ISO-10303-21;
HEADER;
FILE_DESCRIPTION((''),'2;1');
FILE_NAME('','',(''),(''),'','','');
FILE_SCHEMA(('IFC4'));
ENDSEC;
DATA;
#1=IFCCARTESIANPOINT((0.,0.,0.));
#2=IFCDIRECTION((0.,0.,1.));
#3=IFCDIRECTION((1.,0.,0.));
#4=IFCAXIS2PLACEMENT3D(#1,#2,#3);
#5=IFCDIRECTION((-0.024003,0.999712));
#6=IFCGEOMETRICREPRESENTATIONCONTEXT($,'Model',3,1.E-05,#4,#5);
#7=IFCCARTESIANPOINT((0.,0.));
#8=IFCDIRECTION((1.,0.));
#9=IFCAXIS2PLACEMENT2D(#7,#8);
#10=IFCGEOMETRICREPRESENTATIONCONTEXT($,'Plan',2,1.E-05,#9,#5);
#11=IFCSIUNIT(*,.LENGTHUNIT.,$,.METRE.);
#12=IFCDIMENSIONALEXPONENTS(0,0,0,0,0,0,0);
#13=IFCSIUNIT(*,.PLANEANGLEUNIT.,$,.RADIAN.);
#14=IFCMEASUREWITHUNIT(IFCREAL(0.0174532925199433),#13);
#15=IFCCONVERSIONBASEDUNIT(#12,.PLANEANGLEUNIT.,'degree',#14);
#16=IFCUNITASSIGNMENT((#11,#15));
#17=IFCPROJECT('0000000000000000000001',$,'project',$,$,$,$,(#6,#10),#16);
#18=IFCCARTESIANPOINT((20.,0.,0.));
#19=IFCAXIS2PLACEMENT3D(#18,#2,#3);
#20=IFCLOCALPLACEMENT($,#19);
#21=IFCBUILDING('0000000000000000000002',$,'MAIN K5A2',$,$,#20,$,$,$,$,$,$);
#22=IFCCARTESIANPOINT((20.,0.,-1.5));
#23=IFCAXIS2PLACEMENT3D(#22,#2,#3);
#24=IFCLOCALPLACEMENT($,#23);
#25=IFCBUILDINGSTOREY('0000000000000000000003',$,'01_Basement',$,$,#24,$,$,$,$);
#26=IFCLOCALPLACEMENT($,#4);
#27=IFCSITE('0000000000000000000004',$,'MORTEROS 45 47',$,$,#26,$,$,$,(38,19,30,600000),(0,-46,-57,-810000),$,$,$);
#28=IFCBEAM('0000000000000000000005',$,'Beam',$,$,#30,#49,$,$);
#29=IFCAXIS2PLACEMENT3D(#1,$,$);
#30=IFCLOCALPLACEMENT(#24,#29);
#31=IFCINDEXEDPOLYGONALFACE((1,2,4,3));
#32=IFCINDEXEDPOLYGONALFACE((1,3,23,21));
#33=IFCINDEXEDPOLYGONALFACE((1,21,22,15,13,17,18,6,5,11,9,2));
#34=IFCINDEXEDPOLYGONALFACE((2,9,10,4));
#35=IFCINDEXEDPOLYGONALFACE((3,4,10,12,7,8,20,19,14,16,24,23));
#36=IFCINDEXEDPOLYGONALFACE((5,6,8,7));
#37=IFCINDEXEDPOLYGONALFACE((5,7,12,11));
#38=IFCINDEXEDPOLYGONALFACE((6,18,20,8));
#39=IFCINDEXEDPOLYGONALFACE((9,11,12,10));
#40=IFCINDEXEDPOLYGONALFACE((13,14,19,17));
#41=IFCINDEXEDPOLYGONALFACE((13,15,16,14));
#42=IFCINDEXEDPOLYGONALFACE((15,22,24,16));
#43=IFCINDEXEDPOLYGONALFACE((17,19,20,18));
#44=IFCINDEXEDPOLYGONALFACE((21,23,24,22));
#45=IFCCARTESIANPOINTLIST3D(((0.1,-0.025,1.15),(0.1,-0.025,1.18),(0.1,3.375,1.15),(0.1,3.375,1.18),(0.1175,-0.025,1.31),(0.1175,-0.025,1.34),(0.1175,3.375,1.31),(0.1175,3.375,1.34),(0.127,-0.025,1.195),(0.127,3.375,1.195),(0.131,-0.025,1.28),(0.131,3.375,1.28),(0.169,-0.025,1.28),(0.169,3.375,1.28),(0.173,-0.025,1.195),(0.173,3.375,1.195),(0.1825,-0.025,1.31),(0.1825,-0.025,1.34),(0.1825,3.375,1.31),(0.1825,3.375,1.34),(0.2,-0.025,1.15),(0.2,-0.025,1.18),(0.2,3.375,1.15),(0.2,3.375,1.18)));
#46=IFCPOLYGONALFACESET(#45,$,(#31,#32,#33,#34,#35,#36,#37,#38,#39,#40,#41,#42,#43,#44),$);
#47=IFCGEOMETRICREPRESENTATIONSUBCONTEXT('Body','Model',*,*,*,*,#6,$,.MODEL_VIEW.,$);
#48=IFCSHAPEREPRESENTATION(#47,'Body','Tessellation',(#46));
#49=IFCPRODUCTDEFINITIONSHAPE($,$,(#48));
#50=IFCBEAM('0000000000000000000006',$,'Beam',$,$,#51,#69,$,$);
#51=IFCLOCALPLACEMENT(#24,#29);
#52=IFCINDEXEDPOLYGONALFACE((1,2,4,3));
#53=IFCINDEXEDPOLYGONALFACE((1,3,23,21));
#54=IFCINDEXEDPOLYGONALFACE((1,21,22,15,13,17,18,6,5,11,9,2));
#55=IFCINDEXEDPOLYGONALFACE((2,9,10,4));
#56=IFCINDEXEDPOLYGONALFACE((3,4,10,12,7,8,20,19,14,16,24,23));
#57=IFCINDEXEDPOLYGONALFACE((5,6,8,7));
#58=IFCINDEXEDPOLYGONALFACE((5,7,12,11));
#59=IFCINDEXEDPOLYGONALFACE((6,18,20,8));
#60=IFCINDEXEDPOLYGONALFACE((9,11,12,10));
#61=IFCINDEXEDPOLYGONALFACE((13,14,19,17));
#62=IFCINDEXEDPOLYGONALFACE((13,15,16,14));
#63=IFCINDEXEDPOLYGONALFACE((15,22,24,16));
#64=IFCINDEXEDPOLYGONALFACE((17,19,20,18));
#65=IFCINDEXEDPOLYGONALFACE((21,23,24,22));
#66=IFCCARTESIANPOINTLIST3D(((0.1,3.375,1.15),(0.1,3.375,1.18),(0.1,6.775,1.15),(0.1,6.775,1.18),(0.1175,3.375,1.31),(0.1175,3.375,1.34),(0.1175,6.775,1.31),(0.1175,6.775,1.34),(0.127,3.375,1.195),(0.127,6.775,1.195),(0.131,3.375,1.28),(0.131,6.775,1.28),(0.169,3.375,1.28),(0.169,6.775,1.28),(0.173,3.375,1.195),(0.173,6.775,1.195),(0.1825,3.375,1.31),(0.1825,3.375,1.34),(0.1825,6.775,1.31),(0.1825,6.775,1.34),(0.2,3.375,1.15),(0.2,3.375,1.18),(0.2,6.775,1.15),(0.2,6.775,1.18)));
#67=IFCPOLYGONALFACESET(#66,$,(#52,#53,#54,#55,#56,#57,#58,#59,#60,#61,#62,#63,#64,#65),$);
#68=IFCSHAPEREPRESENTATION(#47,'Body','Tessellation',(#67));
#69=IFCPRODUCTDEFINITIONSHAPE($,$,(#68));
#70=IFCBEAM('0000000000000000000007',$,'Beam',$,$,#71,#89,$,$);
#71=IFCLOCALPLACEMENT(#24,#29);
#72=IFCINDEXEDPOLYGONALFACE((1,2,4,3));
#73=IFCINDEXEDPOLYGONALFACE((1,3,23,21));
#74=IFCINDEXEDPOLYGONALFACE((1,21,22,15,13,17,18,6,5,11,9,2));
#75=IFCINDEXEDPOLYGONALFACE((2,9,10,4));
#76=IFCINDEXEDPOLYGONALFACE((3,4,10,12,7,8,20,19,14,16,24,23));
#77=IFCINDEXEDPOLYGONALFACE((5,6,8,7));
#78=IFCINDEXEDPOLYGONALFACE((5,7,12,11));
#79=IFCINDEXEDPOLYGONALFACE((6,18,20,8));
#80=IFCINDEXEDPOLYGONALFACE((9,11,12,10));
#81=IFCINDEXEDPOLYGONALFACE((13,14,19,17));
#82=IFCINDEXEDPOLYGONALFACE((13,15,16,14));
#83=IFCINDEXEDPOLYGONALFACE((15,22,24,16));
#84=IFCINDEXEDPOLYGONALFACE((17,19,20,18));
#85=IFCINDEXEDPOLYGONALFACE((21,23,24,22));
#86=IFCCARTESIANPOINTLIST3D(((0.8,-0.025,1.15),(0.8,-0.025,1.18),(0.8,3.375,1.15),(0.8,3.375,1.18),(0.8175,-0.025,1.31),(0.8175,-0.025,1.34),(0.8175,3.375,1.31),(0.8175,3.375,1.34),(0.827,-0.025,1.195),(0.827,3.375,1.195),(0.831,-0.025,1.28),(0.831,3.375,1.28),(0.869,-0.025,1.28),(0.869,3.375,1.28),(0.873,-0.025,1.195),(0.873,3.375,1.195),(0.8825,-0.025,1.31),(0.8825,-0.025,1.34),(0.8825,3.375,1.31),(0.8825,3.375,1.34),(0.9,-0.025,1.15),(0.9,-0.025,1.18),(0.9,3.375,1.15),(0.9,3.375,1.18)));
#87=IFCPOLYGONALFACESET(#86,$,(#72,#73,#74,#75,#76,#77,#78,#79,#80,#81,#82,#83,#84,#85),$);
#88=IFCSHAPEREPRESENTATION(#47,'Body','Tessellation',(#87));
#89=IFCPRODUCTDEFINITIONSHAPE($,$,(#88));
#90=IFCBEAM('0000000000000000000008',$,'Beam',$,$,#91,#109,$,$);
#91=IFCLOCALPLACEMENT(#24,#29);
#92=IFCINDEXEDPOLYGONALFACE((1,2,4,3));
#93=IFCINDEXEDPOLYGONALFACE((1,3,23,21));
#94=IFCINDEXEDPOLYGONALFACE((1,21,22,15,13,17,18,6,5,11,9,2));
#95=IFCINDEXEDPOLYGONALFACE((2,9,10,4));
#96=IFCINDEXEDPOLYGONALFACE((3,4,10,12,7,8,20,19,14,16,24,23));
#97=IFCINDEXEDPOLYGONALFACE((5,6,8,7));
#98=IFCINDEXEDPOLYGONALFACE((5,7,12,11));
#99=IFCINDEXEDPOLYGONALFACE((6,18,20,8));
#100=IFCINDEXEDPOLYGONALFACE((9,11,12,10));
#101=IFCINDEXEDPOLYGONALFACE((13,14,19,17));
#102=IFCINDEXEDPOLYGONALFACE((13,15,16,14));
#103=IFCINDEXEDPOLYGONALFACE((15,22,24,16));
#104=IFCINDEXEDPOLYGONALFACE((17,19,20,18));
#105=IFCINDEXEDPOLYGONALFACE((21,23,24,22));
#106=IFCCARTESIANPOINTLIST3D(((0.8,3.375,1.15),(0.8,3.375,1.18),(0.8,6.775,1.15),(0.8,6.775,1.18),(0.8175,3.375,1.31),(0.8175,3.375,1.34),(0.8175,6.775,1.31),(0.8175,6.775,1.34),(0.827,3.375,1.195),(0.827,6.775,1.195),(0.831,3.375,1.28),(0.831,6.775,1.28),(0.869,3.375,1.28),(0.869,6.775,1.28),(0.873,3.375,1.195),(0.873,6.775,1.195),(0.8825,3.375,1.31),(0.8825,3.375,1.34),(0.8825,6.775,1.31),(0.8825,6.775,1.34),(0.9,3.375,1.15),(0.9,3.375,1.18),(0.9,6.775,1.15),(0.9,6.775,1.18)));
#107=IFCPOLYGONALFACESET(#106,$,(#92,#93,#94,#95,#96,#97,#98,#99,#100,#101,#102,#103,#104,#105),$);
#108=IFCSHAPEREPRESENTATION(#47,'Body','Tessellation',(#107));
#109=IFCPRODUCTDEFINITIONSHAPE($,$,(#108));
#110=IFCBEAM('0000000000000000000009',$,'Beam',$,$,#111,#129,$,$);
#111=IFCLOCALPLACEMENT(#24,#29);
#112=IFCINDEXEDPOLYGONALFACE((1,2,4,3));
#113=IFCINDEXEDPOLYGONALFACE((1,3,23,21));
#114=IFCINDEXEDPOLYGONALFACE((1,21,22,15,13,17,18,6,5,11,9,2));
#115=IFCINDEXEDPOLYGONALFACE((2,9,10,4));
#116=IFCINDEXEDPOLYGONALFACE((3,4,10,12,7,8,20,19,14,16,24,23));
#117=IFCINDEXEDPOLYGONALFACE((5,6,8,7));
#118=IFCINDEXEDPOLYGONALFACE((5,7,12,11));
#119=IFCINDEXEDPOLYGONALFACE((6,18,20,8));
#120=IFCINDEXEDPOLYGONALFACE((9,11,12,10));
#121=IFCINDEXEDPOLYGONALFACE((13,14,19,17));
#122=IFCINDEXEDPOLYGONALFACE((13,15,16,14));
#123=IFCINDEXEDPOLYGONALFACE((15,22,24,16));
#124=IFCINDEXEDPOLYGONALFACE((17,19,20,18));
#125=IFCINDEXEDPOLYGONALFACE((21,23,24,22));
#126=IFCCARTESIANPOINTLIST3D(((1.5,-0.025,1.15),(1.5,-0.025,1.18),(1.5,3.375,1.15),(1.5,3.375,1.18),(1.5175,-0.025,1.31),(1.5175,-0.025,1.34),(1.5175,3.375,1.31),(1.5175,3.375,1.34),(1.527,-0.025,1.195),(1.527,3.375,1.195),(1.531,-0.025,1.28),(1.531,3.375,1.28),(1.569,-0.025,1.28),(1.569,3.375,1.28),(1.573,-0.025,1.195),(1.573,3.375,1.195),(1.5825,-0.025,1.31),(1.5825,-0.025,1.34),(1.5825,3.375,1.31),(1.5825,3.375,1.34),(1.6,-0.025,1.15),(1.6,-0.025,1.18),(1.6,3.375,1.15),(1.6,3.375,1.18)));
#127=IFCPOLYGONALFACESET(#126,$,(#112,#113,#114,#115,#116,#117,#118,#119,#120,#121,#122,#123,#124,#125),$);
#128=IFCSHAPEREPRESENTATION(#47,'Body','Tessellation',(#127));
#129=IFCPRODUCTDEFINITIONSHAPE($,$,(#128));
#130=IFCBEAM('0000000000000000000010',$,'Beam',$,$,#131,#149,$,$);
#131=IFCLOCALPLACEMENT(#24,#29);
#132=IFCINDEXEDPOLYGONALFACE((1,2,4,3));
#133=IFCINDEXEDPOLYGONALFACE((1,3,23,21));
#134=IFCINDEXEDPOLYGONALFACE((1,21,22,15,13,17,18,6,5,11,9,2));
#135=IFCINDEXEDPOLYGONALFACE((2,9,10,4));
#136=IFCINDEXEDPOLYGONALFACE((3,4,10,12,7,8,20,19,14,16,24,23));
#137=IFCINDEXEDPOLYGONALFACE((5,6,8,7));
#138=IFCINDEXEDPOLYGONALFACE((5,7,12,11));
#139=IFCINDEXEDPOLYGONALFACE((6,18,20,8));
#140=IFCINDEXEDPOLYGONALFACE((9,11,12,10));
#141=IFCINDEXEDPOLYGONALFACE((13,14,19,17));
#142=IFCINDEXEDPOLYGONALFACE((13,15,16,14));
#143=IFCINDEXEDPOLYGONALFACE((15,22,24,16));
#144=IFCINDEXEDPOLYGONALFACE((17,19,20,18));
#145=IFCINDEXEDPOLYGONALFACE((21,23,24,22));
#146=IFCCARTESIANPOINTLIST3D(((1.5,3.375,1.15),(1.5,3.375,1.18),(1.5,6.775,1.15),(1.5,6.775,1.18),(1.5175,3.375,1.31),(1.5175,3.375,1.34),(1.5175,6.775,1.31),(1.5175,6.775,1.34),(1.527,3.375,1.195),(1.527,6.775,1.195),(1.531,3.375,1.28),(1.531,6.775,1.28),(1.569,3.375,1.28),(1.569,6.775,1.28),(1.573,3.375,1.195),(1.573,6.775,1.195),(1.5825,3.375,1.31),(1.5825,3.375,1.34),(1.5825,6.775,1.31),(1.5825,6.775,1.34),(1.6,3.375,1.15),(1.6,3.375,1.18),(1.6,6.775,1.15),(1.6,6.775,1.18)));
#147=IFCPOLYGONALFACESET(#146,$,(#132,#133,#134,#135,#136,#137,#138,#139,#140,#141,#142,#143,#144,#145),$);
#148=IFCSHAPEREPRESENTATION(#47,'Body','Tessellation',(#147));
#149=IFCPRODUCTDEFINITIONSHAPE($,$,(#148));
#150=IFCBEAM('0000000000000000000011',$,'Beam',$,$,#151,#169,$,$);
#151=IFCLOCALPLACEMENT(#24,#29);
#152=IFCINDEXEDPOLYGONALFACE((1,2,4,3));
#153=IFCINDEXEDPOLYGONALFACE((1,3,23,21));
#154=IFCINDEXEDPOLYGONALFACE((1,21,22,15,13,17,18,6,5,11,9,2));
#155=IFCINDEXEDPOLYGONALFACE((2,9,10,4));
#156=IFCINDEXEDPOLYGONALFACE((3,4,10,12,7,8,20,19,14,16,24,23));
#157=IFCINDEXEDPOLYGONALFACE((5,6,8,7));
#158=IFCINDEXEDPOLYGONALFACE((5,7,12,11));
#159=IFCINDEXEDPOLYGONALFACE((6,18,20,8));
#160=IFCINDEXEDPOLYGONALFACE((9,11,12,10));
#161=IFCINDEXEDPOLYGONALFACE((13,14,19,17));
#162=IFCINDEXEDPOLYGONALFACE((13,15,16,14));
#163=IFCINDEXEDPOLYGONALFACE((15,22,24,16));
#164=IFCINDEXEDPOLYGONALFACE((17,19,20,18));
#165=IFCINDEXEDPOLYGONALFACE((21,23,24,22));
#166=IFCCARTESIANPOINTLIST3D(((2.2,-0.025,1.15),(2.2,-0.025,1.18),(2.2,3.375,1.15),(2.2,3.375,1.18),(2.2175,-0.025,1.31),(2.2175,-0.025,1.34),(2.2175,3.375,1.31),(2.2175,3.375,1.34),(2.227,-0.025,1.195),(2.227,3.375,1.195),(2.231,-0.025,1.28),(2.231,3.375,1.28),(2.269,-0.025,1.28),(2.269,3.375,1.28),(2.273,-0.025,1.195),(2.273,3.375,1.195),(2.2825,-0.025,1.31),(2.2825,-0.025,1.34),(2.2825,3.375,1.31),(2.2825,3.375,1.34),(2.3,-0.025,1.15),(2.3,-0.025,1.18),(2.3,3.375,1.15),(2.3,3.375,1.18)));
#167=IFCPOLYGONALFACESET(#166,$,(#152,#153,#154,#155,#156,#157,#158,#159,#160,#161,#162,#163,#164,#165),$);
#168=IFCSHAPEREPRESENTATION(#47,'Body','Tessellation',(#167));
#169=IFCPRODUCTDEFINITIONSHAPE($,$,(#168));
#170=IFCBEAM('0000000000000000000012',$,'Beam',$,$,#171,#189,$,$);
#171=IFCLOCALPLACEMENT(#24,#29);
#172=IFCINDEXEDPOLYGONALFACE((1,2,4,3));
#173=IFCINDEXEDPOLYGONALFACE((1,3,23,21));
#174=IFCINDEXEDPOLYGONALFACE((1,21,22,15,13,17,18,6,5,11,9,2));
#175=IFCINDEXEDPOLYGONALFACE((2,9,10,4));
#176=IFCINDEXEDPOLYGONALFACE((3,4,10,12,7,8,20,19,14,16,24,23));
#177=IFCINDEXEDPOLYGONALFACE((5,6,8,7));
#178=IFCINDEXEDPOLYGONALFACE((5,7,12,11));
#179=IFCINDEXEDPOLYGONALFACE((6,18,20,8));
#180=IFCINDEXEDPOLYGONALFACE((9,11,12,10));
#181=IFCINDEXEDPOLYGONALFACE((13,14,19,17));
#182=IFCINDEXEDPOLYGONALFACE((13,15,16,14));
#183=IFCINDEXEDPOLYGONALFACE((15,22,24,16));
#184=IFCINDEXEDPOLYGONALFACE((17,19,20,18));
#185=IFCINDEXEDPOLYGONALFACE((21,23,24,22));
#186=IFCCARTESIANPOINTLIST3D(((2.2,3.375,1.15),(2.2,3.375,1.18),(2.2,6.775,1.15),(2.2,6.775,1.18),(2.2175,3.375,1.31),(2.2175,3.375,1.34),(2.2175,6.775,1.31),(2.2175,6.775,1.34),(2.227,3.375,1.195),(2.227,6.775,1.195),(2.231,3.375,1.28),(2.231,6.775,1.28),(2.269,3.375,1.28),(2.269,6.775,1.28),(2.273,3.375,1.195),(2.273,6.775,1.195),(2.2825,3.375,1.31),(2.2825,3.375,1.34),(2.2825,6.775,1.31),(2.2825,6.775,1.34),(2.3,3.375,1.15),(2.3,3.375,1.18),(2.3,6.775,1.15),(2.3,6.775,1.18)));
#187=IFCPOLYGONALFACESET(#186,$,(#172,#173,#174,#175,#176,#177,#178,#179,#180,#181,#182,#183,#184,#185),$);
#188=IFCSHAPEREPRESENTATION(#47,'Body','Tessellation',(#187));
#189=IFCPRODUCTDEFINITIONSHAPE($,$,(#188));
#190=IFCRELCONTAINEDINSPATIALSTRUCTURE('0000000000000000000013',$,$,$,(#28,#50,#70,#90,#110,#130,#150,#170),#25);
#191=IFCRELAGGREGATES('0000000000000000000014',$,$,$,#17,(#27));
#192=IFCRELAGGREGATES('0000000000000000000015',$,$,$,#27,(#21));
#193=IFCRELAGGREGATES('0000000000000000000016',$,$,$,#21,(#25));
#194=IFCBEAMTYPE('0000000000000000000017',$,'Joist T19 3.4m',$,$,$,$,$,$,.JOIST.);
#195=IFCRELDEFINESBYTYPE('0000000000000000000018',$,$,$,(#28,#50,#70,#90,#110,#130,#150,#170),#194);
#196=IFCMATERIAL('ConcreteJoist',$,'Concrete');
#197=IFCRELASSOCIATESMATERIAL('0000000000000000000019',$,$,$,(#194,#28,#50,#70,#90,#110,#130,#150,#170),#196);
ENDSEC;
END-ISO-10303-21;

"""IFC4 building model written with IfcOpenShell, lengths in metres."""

from ifc_helpers import new_model, entity, si_unit, converted_unit, direction, frame, origin_with_axes, origin_2d_with_axis, place, context, subcontext, project, spatial, indexed_curve, outline, extrude, material, material_profile, profile_set, profile_usage, type_object, element, save


model = new_model("IFC4")

# Units and contexts
model_context = context("Model", 3, precision=1e-05, world=origin_with_axes(), true_north=direction((-0.024003, 0.999712)))
plan_context = context("Plan", 2, precision=1e-05, world=origin_2d_with_axis(), true_north=direction((-0.024003, 0.999712)))
body_context = subcontext(model_context, "Body", "Model", "MODEL_VIEW")
ifc_project = project(units=[si_unit("LENGTHUNIT", "METRE"), converted_unit("PLANEANGLEUNIT", "degree", entity("IfcReal", 0.0174532925199433), si_unit("PLANEANGLEUNIT", "RADIAN"), dimensions=[0, 0, 0, 0, 0, 0, 0])], contexts=[model_context, plan_context])

# Site, building, storey
site_placement = place(None, origin_with_axes())
site = spatial("IfcSite", under=ifc_project, at=site_placement, Name="MORTEROS 45 47", RefLatitude=(38, 19, 30, 600000), RefLongitude=(0, -46, -57, -810000))
building_placement = place(None, frame((20.0, 0.0, 0.0), z_axis=(0.0, 0.0, 1.0), x_axis=(1.0, 0.0, 0.0)))
building = spatial("IfcBuilding", under=site, at=building_placement, Name="MAIN K5A2")
storey_placement = place(None, frame((20.0, 0.0, -1.5), z_axis=(0.0, 0.0, 1.0), x_axis=(1.0, 0.0, 0.0)))
storey = spatial("IfcBuildingStorey", under=building, at=storey_placement, Name="01_Basement")

# Beams
ifc_material = material(Name="ConcreteJoist", Category="Concrete")
ifc_material_profile = material_profile(ifc_material, outline(indexed_curve([(0.019, 0.13), (0.023, 0.045), (0.05, 0.03), (0.05, 0.0), (-0.05, 0.0), (-0.05, 0.03), (-0.023, 0.045), (-0.019, 0.13), (-0.0325, 0.16), (-0.0325, 0.19), (0.0325, 0.19), (0.0325, 0.16), (0.019, 0.13)])))
ifc_profile_set = profile_set([ifc_material_profile], Name="JoistMaterialProfileSet")
ifc_profile_usage_1 = profile_usage(ifc_profile_set, cardinal=5)
beam_type = type_object("IfcBeamType", Name="Joist T19 3.4m", PredefinedType="JOIST", material=ifc_profile_set)
beam_1_placement = place(None, frame((20.15, -0.025, -0.35), z_axis=(0.0, 1.0, 0.0), x_axis=(-1.0, 0.0, 0.0)))
element("IfcBeam", 1, at=beam_1_placement, inside=storey, type_object=beam_type, material=ifc_profile_usage_1, Name="Beam", context=body_context, shape_type="SweptSolid", body=[
    extrude(outline(indexed_curve([(0.019, 0.13), (0.023, 0.045), (0.05, 0.03), (0.05, 0.0), (-0.05, 0.0), (-0.05, 0.03), (-0.023, 0.045), (-0.019, 0.13), (-0.0325, 0.16), (-0.0325, 0.19), (0.0325, 0.19), (0.0325, 0.16), (0.019, 0.13)])), origin_with_axes(), (0.0, 0.0, 1.0), 3.4),
])
ifc_profile_usage_2 = profile_usage(ifc_profile_set, cardinal=5)
beam_2_placement = place(None, frame((20.15, 3.375, -0.35), z_axis=(0.0, 1.0, 0.0), x_axis=(-1.0, 0.0, 0.0)))
element("IfcBeam", 2, at=beam_2_placement, inside=storey, type_object=beam_type, material=ifc_profile_usage_2, Name="Beam", context=body_context, shape_type="SweptSolid", body=[
    extrude(outline(indexed_curve([(0.019, 0.13), (0.023, 0.045), (0.05, 0.03), (0.05, 0.0), (-0.05, 0.0), (-0.05, 0.03), (-0.023, 0.045), (-0.019, 0.13), (-0.0325, 0.16), (-0.0325, 0.19), (0.0325, 0.19), (0.0325, 0.16), (0.019, 0.13)])), origin_with_axes(), (0.0, 0.0, 1.0), 3.4),
])
ifc_profile_usage_3 = profile_usage(ifc_profile_set, cardinal=5)
beam_3_placement = place(None, frame((20.85, -0.025, -0.35), z_axis=(0.0, 1.0, 0.0), x_axis=(-1.0, 0.0, 0.0)))
element("IfcBeam", 3, at=beam_3_placement, inside=storey, type_object=beam_type, material=ifc_profile_usage_3, Name="Beam", context=body_context, shape_type="SweptSolid", body=[
    extrude(outline(indexed_curve([(0.019, 0.13), (0.023, 0.045), (0.05, 0.03), (0.05, 0.0), (-0.05, 0.0), (-0.05, 0.03), (-0.023, 0.045), (-0.019, 0.13), (-0.0325, 0.16), (-0.0325, 0.19), (0.0325, 0.19), (0.0325, 0.16), (0.019, 0.13)])), origin_with_axes(), (0.0, 0.0, 1.0), 3.4),
])
ifc_profile_usage_4 = profile_usage(ifc_profile_set, cardinal=5)
beam_4_placement = place(None, frame((20.85, 3.375, -0.35), z_axis=(0.0, 1.0, 0.0), x_axis=(-1.0, 0.0, 0.0)))
element("IfcBeam", 4, at=beam_4_placement, inside=storey, type_object=beam_type, material=ifc_profile_usage_4, Name="Beam", context=body_context, shape_type="SweptSolid", body=[
    extrude(outline(indexed_curve([(0.019, 0.13), (0.023, 0.045), (0.05, 0.03), (0.05, 0.0), (-0.05, 0.0), (-0.05, 0.03), (-0.023, 0.045), (-0.019, 0.13), (-0.0325, 0.16), (-0.0325, 0.19), (0.0325, 0.19), (0.0325, 0.16), (0.019, 0.13)])), origin_with_axes(), (0.0, 0.0, 1.0), 3.4),
])
ifc_profile_usage_5 = profile_usage(ifc_profile_set, cardinal=5)
beam_5_placement = place(None, frame((21.55, -0.025, -0.35), z_axis=(0.0, 1.0, 0.0), x_axis=(-1.0, 0.0, 0.0)))
element("IfcBeam", 5, at=beam_5_placement, inside=storey, type_object=beam_type, material=ifc_profile_usage_5, Name="Beam", context=body_context, shape_type="SweptSolid", body=[
    extrude(outline(indexed_curve([(0.019, 0.13), (0.023, 0.045), (0.05, 0.03), (0.05, 0.0), (-0.05, 0.0), (-0.05, 0.03), (-0.023, 0.045), (-0.019, 0.13), (-0.0325, 0.16), (-0.0325, 0.19), (0.0325, 0.19), (0.0325, 0.16), (0.019, 0.13)])), origin_with_axes(), (0.0, 0.0, 1.0), 3.4),
])
ifc_profile_usage_6 = profile_usage(ifc_profile_set, cardinal=5)
beam_6_placement = place(None, frame((21.55, 3.375, -0.35), z_axis=(0.0, 1.0, 0.0), x_axis=(-1.0, 0.0, 0.0)))
element("IfcBeam", 6, at=beam_6_placement, inside=storey, type_object=beam_type, material=ifc_profile_usage_6, Name="Beam", context=body_context, shape_type="SweptSolid", body=[
    extrude(outline(indexed_curve([(0.019, 0.13), (0.023, 0.045), (0.05, 0.03), (0.05, 0.0), (-0.05, 0.0), (-0.05, 0.03), (-0.023, 0.045), (-0.019, 0.13), (-0.0325, 0.16), (-0.0325, 0.19), (0.0325, 0.19), (0.0325, 0.16), (0.019, 0.13)])), origin_with_axes(), (0.0, 0.0, 1.0), 3.4),
])
ifc_profile_usage_7 = profile_usage(ifc_profile_set, cardinal=5)
beam_7_placement = place(None, frame((22.25, -0.025, -0.35), z_axis=(0.0, 1.0, 0.0), x_axis=(-1.0, 0.0, 0.0)))
element("IfcBeam", 7, at=beam_7_placement, inside=storey, type_object=beam_type, material=ifc_profile_usage_7, Name="Beam", context=body_context, shape_type="SweptSolid", body=[
    extrude(outline(indexed_curve([(0.019, 0.13), (0.023, 0.045), (0.05, 0.03), (0.05, 0.0), (-0.05, 0.0), (-0.05, 0.03), (-0.023, 0.045), (-0.019, 0.13), (-0.0325, 0.16), (-0.0325, 0.19), (0.0325, 0.19), (0.0325, 0.16), (0.019, 0.13)])), origin_with_axes(), (0.0, 0.0, 1.0), 3.4),
])
ifc_profile_usage_8 = profile_usage(ifc_profile_set, cardinal=5)
beam_8_placement = place(None, frame((22.25, 3.375, -0.35), z_axis=(0.0, 1.0, 0.0), x_axis=(-1.0, 0.0, 0.0)))
element("IfcBeam", 8, at=beam_8_placement, inside=storey, type_object=beam_type, material=ifc_profile_usage_8, Name="Beam", context=body_context, shape_type="SweptSolid", body=[
    extrude(outline(indexed_curve([(0.019, 0.13), (0.023, 0.045), (0.05, 0.03), (0.05, 0.0), (-0.05, 0.0), (-0.05, 0.03), (-0.023, 0.045), (-0.019, 0.13), (-0.0325, 0.16), (-0.0325, 0.19), (0.0325, 0.19), (0.0325, 0.16), (0.019, 0.13)])), origin_with_axes(), (0.0, 0.0, 1.0), 3.4),
])

save(model, "model.ifc")
